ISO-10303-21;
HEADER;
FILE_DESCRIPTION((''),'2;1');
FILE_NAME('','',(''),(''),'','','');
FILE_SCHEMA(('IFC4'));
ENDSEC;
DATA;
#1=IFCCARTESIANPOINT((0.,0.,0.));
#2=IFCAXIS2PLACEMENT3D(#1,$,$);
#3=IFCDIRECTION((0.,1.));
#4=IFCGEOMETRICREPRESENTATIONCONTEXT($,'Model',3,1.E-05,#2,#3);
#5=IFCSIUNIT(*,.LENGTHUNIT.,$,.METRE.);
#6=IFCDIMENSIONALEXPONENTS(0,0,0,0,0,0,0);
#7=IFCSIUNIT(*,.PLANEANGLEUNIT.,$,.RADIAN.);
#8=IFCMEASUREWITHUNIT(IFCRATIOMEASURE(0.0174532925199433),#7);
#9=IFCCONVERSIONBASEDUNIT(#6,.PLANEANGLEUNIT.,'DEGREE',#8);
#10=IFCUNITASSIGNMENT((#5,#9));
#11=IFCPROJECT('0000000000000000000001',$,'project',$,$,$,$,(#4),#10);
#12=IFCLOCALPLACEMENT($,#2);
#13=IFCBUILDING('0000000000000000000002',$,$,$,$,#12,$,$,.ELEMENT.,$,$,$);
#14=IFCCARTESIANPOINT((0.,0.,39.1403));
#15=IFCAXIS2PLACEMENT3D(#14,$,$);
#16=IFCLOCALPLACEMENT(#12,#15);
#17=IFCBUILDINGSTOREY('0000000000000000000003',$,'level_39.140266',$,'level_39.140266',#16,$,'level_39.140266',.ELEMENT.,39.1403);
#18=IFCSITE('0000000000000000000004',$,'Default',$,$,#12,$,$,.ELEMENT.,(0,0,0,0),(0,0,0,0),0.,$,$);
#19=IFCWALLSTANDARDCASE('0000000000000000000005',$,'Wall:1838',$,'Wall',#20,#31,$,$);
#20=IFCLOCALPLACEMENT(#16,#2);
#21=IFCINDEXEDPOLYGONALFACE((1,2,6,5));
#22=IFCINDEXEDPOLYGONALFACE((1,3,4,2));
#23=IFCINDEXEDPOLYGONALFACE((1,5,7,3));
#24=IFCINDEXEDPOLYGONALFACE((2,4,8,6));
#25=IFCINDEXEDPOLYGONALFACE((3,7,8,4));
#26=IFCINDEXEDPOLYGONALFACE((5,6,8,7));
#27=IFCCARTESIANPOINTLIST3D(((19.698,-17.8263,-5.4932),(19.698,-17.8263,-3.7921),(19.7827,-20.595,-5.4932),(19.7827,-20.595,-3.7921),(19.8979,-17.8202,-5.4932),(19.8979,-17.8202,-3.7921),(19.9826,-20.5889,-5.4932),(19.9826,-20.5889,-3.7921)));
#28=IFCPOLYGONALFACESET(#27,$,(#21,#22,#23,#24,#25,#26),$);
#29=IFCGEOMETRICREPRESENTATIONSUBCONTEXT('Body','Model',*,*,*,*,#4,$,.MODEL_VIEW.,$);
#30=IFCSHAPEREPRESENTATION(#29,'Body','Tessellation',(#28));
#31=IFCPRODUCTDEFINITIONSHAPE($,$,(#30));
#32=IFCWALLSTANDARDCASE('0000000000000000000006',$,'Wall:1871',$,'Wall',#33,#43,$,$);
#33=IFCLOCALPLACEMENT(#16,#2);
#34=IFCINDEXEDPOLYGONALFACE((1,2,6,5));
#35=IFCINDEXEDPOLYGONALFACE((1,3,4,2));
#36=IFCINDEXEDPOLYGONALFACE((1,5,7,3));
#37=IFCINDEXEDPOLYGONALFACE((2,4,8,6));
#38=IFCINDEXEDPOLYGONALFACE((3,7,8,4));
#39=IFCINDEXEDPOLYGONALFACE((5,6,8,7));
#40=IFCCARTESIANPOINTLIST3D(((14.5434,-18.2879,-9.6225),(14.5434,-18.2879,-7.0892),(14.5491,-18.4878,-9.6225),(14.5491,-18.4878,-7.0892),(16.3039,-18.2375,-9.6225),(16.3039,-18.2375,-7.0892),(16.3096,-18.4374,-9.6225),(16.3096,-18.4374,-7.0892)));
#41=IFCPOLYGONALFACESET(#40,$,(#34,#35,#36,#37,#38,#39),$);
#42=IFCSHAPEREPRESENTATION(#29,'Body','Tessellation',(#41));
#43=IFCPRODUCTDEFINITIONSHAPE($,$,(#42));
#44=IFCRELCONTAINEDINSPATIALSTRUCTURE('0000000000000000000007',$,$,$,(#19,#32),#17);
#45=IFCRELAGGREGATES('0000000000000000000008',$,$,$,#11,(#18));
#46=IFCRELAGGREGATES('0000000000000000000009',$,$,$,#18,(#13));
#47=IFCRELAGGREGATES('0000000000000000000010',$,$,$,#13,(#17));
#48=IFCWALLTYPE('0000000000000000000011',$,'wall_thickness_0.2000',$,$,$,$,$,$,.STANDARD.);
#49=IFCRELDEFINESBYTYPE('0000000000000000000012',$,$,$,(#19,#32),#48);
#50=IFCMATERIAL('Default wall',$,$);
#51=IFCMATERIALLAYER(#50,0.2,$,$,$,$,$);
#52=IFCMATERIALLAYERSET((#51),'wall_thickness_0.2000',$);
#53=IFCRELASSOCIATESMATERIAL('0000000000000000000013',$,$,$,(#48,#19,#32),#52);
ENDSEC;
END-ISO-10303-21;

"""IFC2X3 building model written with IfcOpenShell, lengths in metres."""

from ifc_helpers import new_model, entity, si_unit, converted_unit, direction, frame, origin, place, context, subcontext, project, spatial, polyline, outline, extrude, material, layer, layer_set, layer_usage, type_object, element, save


model = new_model("IFC2X3")

# Units and contexts
model_context = context("Model", 3, precision=1e-05, world=origin(), true_north=direction((0.0, 1.0)))
body_context = subcontext(model_context, "Body", "Model", "MODEL_VIEW")
ifc_project = project(units=[si_unit("LENGTHUNIT", "METRE"), converted_unit("PLANEANGLEUNIT", "DEGREE", entity("IfcRatioMeasure", 0.0174532925199433), si_unit("PLANEANGLEUNIT", "RADIAN"), dimensions=[0, 0, 0, 0, 0, 0, 0])], contexts=[model_context])

# Site, building, storey
placement_1 = place(None, origin())
site = spatial("IfcSite", under=ifc_project, at=placement_1, Name="Default", CompositionType="ELEMENT", RefLatitude=(0, 0, 0, 0), RefLongitude=(0, 0, 0, 0), RefElevation=0.0)
building = spatial("IfcBuilding", under=site, at=placement_1, CompositionType="ELEMENT")
storey_placement = place(placement_1, frame((0.0, 0.0, 39.1403)))
storey = spatial("IfcBuildingStorey", under=building, at=storey_placement, Name="level_39.140266", ObjectType="level_39.140266", LongName="level_39.140266", CompositionType="ELEMENT", Elevation=39.1403)

# Shared definitions
ifc_material_1 = material(Name="Default wall")
ifc_layer = layer(ifc_material_1, 0.2)
ifc_layer_set = layer_set([ifc_layer], Name="wall_thickness_0.2000")
ifc_layer_usage = layer_usage(ifc_layer_set, "AXIS2", "POSITIVE", -0.1)
wall_type = type_object("IfcWallType", Name="wall_thickness_0.2000", PredefinedType="STANDARD", material=ifc_layer_set)

# Walls
placement_2 = place(placement_1, frame((0.0, 0.0, 33.6471)))
wall_1_placement = place(placement_2, frame((19.8827, -20.5919, 0.0), z_axis=(0.0, 0.0, 1.0), x_axis=(-0.030564, 0.999533, 0.0)))
element("IfcWallStandardCase", 1, at=wall_1_placement, inside=storey, type_object=wall_type, material=ifc_layer_usage, Name="Wall:1838", ObjectType="Wall", context=body_context, shape_type="SweptSolid", body=[
    extrude(outline(polyline([(2.77, -0.1), (2.77, 0.1), (0.0, 0.1), (0.0, -0.1), (2.77, -0.1)])), origin(), (0.0, 0.0, 1.0), 1.7011),
])
placement_3 = place(placement_1, frame((0.0, 0.0, 29.5178)))
wall_2_placement = place(placement_3, frame((16.3067, -18.3375, 0.0), z_axis=(0.0, 0.0, 1.0), x_axis=(-0.999591, -0.028582, 0.0)))
element("IfcWallStandardCase", 2, at=wall_2_placement, inside=storey, type_object=wall_type, material=ifc_layer_usage, Name="Wall:1871", ObjectType="Wall", context=body_context, shape_type="SweptSolid", body=[
    extrude(outline(polyline([(1.7612, -0.1), (1.7612, 0.1), (0.0, 0.1), (0.0, -0.1), (1.7612, -0.1)])), origin(), (0.0, 0.0, 1.0), 2.5333),
])

save(model, "model.ifc")
